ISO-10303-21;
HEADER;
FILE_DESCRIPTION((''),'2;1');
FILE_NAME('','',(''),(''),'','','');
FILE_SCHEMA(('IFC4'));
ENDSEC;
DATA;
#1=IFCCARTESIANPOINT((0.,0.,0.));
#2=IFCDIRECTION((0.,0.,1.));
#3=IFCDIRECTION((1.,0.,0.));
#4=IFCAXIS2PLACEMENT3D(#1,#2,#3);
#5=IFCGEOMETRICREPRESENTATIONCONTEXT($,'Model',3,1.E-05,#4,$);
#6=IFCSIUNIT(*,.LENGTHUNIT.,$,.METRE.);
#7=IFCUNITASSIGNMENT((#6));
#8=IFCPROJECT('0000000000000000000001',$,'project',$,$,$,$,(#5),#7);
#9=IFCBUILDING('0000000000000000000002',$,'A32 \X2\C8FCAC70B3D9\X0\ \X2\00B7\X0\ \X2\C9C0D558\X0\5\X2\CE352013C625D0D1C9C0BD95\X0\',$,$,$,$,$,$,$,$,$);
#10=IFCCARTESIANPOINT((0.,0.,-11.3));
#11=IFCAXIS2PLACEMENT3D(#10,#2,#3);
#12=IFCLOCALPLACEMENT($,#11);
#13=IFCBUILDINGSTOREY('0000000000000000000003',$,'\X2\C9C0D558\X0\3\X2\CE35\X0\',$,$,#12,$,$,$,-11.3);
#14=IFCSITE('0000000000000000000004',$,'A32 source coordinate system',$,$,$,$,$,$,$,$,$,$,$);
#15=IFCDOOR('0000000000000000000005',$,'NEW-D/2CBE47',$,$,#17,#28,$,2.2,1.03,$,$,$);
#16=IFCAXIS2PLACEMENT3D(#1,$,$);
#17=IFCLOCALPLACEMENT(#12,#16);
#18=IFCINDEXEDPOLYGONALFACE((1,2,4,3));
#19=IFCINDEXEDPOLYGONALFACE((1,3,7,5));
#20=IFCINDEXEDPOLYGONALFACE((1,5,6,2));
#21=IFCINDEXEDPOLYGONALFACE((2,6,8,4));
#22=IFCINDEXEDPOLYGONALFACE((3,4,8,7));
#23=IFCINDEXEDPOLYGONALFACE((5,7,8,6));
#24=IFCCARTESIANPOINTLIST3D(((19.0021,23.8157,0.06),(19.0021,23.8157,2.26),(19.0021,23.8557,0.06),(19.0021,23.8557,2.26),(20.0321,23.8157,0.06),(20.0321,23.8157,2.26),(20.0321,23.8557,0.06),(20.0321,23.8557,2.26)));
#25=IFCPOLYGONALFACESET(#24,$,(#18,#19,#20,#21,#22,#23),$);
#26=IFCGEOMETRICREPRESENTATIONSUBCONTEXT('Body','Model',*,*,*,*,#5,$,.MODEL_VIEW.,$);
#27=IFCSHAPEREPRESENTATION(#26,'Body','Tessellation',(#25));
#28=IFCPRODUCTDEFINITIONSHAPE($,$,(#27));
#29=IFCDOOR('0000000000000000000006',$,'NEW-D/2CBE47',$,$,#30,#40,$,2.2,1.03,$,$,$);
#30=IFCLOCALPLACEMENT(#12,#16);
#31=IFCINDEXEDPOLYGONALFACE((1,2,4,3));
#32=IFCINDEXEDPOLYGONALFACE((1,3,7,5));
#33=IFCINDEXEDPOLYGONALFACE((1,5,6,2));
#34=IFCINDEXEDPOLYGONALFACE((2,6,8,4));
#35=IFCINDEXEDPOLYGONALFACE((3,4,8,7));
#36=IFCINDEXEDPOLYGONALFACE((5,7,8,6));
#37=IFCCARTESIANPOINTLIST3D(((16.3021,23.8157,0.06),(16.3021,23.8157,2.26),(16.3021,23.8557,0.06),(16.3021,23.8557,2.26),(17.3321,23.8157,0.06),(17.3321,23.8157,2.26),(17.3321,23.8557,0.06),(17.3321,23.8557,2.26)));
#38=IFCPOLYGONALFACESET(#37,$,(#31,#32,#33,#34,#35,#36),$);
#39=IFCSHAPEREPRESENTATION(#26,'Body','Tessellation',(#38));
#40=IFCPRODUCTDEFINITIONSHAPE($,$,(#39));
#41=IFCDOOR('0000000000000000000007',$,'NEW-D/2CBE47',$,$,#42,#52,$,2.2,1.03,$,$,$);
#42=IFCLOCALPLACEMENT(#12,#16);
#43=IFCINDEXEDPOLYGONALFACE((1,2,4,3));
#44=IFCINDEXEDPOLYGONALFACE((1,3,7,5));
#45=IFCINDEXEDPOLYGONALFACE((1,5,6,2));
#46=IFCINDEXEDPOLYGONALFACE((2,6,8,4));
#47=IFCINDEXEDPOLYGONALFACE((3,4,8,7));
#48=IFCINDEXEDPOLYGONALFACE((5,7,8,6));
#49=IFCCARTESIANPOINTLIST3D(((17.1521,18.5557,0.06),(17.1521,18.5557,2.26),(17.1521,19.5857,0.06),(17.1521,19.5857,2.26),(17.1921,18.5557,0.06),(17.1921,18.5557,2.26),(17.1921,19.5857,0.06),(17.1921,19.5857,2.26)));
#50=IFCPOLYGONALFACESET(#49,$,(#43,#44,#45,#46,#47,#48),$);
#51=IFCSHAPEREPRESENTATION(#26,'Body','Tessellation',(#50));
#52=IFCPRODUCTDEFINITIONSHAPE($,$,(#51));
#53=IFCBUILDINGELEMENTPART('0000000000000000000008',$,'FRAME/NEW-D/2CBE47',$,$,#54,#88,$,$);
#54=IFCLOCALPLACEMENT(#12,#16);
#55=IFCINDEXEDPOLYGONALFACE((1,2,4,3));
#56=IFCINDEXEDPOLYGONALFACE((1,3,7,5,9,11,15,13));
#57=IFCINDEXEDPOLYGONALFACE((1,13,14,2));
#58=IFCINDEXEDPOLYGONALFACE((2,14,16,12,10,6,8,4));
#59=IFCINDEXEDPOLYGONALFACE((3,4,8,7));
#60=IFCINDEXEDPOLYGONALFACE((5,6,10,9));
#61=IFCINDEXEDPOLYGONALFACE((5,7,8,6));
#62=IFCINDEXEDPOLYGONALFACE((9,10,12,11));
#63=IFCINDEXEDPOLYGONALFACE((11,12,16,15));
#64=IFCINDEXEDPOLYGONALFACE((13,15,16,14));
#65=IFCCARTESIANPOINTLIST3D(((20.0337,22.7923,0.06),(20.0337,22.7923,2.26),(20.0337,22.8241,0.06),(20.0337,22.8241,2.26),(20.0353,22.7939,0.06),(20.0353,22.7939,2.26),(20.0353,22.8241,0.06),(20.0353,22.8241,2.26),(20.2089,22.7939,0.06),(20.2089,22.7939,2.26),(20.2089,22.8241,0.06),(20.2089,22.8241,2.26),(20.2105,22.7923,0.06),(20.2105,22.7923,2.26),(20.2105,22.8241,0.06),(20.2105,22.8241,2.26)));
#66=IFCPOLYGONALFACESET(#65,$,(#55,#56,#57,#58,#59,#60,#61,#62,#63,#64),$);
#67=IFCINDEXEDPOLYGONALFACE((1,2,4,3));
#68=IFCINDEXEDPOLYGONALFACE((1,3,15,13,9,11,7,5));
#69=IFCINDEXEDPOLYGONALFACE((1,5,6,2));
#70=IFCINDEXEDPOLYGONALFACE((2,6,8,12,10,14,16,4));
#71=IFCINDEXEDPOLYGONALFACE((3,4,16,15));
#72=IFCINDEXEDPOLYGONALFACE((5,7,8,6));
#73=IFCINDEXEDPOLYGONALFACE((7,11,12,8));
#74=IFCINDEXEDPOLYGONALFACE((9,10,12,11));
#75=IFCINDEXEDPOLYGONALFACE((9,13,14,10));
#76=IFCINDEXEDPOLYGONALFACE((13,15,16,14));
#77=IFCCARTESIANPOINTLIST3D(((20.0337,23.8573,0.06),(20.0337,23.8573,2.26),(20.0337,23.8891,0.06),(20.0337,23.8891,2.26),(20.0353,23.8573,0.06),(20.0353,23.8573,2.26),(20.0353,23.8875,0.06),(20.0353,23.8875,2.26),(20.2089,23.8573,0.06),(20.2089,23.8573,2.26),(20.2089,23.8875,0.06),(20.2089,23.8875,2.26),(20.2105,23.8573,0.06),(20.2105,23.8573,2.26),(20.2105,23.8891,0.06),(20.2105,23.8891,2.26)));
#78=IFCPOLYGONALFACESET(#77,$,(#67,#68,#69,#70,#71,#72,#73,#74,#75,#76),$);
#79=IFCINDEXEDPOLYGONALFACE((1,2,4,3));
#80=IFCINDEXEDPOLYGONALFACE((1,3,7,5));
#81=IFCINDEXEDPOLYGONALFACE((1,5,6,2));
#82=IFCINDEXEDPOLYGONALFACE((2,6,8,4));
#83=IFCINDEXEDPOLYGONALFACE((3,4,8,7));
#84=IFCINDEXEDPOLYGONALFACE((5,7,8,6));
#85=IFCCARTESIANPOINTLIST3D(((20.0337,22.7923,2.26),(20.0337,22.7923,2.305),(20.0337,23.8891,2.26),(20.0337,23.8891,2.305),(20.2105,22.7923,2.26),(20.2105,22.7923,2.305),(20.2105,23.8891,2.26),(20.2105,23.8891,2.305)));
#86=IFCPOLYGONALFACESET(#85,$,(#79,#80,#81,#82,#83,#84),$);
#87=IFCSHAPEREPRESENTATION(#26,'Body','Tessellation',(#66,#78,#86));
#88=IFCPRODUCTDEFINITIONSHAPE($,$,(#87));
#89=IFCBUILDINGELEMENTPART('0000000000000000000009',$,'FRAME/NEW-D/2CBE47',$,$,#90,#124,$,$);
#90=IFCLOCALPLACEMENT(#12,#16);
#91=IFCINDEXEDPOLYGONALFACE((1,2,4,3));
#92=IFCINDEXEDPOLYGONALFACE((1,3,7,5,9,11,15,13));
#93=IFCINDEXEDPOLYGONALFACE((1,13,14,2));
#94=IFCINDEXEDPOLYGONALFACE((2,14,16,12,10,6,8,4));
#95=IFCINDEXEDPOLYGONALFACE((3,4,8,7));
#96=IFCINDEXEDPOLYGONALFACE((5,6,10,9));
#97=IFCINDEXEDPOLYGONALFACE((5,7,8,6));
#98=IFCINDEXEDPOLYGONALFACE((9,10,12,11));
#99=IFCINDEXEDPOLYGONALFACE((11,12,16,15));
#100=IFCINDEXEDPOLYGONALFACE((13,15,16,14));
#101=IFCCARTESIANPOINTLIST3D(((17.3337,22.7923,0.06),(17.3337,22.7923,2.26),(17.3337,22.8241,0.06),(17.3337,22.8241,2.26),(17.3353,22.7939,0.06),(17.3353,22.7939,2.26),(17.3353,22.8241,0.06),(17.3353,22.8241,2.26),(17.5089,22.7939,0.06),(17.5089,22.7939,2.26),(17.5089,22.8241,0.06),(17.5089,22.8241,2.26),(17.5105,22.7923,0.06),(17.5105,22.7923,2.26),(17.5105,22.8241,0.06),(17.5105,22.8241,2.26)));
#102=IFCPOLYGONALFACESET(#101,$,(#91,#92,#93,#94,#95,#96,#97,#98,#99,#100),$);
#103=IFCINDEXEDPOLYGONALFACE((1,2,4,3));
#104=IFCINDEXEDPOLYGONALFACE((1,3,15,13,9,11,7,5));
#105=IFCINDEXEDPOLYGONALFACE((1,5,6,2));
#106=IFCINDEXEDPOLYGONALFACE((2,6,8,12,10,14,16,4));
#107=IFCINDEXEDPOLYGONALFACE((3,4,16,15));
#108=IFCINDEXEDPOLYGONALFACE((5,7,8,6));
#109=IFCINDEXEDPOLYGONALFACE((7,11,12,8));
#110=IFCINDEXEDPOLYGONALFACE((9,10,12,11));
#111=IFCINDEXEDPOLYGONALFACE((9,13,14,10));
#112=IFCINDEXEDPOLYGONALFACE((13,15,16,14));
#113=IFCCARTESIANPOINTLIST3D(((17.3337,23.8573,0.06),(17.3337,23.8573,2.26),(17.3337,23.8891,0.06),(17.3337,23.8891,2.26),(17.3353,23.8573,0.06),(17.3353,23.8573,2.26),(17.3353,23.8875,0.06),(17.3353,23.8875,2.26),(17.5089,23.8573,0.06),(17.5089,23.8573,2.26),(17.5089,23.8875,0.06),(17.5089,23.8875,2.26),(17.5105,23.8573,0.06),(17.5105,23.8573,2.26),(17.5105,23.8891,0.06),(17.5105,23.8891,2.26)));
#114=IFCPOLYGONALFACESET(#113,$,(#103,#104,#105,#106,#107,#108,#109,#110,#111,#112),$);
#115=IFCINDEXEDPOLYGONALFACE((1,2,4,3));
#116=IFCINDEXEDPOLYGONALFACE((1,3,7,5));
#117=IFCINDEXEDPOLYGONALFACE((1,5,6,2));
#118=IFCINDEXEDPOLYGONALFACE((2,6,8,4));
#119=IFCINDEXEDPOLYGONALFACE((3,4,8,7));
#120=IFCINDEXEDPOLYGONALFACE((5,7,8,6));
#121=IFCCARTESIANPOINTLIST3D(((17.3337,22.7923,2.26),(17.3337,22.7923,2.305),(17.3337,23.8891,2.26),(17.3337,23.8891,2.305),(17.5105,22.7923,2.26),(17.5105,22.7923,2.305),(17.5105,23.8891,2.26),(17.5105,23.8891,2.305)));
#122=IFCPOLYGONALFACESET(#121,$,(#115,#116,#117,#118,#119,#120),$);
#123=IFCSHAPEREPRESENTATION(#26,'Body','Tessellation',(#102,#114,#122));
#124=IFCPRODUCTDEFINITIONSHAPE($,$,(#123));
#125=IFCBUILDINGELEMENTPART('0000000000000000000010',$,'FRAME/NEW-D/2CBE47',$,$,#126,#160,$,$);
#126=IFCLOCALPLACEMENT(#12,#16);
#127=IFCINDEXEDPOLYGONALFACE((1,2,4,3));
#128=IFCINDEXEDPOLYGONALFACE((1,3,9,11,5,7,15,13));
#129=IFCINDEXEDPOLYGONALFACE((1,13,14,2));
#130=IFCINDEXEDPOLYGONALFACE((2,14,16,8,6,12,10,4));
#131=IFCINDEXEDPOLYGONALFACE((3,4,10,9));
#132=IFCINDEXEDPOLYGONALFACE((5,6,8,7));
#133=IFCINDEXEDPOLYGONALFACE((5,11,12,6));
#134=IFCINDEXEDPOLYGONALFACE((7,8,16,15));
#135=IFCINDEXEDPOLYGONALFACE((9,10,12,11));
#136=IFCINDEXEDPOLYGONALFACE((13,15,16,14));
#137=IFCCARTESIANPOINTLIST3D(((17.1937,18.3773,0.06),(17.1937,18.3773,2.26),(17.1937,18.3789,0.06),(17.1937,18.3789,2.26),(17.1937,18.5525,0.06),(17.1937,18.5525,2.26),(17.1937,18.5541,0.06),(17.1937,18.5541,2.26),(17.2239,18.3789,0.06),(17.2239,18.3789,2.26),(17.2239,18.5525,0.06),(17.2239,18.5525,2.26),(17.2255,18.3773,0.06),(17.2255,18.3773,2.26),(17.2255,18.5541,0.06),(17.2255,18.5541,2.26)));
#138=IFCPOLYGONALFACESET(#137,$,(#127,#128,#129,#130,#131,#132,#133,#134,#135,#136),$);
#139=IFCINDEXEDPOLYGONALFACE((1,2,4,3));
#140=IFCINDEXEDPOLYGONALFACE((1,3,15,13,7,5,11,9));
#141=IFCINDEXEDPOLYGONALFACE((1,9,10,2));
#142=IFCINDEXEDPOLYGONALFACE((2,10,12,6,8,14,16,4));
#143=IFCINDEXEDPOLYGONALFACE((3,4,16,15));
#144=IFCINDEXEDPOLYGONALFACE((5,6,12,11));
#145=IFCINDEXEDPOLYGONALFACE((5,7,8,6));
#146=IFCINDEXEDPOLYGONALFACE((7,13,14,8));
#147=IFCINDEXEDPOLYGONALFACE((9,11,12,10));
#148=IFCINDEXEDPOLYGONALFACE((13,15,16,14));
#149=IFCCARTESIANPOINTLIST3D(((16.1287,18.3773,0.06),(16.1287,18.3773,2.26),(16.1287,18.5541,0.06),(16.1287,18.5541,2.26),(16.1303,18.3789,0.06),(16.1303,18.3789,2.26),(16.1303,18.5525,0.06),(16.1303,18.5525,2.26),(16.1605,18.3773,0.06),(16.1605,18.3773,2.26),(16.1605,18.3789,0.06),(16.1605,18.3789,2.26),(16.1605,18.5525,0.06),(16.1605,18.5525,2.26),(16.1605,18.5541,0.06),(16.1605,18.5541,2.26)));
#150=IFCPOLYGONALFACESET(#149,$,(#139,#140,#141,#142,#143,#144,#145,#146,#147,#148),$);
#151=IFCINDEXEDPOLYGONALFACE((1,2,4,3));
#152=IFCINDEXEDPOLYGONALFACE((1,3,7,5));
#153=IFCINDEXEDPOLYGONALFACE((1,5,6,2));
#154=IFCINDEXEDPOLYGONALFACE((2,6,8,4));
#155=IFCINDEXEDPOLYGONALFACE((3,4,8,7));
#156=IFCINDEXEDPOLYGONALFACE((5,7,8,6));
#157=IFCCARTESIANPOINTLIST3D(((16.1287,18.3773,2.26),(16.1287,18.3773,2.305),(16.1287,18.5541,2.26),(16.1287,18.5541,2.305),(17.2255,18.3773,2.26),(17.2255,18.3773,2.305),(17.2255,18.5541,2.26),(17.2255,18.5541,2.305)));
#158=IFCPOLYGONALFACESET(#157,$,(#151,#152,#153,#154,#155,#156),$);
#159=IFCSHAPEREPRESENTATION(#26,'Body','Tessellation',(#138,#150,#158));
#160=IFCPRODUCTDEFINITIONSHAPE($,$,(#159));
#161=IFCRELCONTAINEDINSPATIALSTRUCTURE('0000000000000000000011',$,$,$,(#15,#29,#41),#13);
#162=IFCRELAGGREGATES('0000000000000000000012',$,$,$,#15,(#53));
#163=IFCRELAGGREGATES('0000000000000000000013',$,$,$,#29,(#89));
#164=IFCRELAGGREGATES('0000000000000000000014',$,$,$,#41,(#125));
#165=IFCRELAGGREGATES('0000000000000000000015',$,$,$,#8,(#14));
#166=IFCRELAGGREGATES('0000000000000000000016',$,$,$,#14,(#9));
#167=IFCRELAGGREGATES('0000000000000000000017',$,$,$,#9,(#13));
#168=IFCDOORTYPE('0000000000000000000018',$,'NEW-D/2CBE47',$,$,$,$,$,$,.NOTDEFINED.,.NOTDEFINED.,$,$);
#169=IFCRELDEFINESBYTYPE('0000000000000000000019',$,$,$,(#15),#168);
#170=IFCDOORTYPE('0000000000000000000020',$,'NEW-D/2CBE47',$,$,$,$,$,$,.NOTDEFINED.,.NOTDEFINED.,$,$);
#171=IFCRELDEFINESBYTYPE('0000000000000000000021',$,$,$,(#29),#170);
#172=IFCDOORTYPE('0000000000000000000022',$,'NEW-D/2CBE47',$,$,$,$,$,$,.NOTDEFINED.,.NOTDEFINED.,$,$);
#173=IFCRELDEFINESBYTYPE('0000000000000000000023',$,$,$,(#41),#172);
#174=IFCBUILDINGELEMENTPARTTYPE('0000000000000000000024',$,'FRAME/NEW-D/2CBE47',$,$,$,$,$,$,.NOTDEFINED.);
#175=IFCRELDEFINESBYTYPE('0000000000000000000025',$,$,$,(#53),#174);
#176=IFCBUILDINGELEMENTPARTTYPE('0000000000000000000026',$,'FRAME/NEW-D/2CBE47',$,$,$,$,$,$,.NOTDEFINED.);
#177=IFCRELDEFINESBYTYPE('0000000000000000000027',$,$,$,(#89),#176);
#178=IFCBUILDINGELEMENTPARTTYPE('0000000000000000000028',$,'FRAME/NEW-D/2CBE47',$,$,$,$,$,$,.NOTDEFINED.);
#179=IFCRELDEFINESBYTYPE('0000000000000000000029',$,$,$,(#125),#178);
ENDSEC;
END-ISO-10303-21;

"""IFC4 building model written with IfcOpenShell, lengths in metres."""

from ifc_helpers import new_model, si_unit, frame, origin, origin_with_axes, place, context, subcontext, project, spatial, polyline, outline, extrude, source, transform, mapped, type_object, type_shapes, element, aggregate, save


model = new_model("IFC4")

# Units and contexts
model_context = context("Model", 3, precision=1e-05, world=origin_with_axes())
body_context = subcontext(model_context, "Body", "Model", "MODEL_VIEW")
ifc_project = project(units=[si_unit("LENGTHUNIT", "METRE")], contexts=[model_context])

# Site, building, storey
site = spatial("IfcSite", under=ifc_project, Name="A32 source coordinate system")
building = spatial("IfcBuilding", under=site, Name="A32 주거동 · 지하5층–옥탑지붕")
storey_placement = place(None, frame((0.0, 0.0, -11.3), z_axis=(0.0, 0.0, 1.0), x_axis=(1.0, 0.0, 0.0)))
storey = spatial("IfcBuildingStorey", under=building, at=storey_placement, Name="지하3층", Elevation=-11.3)

# Doors
door_type_1 = type_object("IfcDoorType", Name="NEW-D/2CBE47", OperationType="NOTDEFINED", PredefinedType="NOTDEFINED")
shared_shape_1 = source(origin(), body_context, "Body", "SweptSolid", [
    extrude(outline(polyline([(20.0321, 23.8557), (20.0321, 23.8157), (19.0021, 23.8157), (19.0021, 23.8557), (20.0321, 23.8557)])), frame((0.0, 0.0, 0.06)), (0.0, 0.0, 1.0), 2.2),
])
type_shapes(door_type_1, [shared_shape_1])
door_1_placement = place(storey_placement, origin_with_axes())
door_1 = element("IfcDoor", 1, at=door_1_placement, inside=storey, type_object=door_type_1, Name="NEW-D/2CBE47", OverallHeight=2.2, OverallWidth=1.03, context=body_context, shape_type="MappedRepresentation", body=[
    mapped(shared_shape_1, transform((0.0, 0.0, 0.0), scale=1.0)),
])
door_type_2 = type_object("IfcDoorType", Name="NEW-D/2CBE47", OperationType="NOTDEFINED", PredefinedType="NOTDEFINED")
shared_shape_2 = source(origin(), body_context, "Body", "SweptSolid", [
    extrude(outline(polyline([(17.3321, 23.8557), (17.3321, 23.8157), (16.3021, 23.8157), (16.3021, 23.8557), (17.3321, 23.8557)])), frame((0.0, 0.0, 0.06)), (0.0, 0.0, 1.0), 2.2),
])
type_shapes(door_type_2, [shared_shape_2])
door_2_placement = place(storey_placement, origin_with_axes())
door_2 = element("IfcDoor", 2, at=door_2_placement, inside=storey, type_object=door_type_2, Name="NEW-D/2CBE47", OverallHeight=2.2, OverallWidth=1.03, context=body_context, shape_type="MappedRepresentation", body=[
    mapped(shared_shape_2, transform((0.0, 0.0, 0.0), scale=1.0)),
])
door_type_3 = type_object("IfcDoorType", Name="NEW-D/2CBE47", OperationType="NOTDEFINED", PredefinedType="NOTDEFINED")
shared_shape_3 = source(origin(), body_context, "Body", "SweptSolid", [
    extrude(outline(polyline([(17.1921, 18.5557), (17.1521, 18.5557), (17.1521, 19.5857), (17.1921, 19.5857), (17.1921, 18.5557)])), frame((0.0, 0.0, 0.06)), (0.0, 0.0, 1.0), 2.2),
])
type_shapes(door_type_3, [shared_shape_3])
door_3_placement = place(storey_placement, origin_with_axes())
door_3 = element("IfcDoor", 3, at=door_3_placement, inside=storey, type_object=door_type_3, Name="NEW-D/2CBE47", OverallHeight=2.2, OverallWidth=1.03, context=body_context, shape_type="MappedRepresentation", body=[
    mapped(shared_shape_3, transform((0.0, 0.0, 0.0), scale=1.0)),
])

# Building element parts
building_element_part_type_1 = type_object("IfcBuildingElementPartType", Name="FRAME/NEW-D/2CBE47", PredefinedType="NOTDEFINED")
shared_shape_4 = source(origin(), body_context, "Body", "SweptSolid", [
    extrude(outline(polyline([(20.0353, 22.7939), (20.2089, 22.7939), (20.2089, 22.8241), (20.2105, 22.8241), (20.2105, 22.7923), (20.0337, 22.7923), (20.0337, 22.8241), (20.0353, 22.8241), (20.0353, 22.7939)])), frame((0.0, 0.0, 0.06)), (0.0, 0.0, 1.0), 2.2),
    extrude(outline(polyline([(20.2105, 23.8891), (20.2105, 23.8573), (20.2089, 23.8573), (20.2089, 23.8875), (20.0353, 23.8875), (20.0353, 23.8573), (20.0337, 23.8573), (20.0337, 23.8891), (20.2105, 23.8891)])), frame((0.0, 0.0, 0.06)), (0.0, 0.0, 1.0), 2.2),
    extrude(outline(polyline([(20.2105, 22.7923), (20.2105, 23.8891), (20.0337, 23.8891), (20.0337, 22.7923), (20.2105, 22.7923)])), frame((0.0, 0.0, 2.26)), (0.0, 0.0, 1.0), 0.045),
])
type_shapes(building_element_part_type_1, [shared_shape_4])
building_element_part_1_placement = place(door_1_placement, origin_with_axes())
building_element_part_1 = element("IfcBuildingElementPart", 4, at=building_element_part_1_placement, type_object=building_element_part_type_1, Name="FRAME/NEW-D/2CBE47", context=body_context, shape_type="MappedRepresentation", body=[
    mapped(shared_shape_4, transform((0.0, 0.0, 0.0), scale=1.0)),
])
aggregate(door_1, [building_element_part_1])
building_element_part_type_2 = type_object("IfcBuildingElementPartType", Name="FRAME/NEW-D/2CBE47", PredefinedType="NOTDEFINED")
shared_shape_5 = source(origin(), body_context, "Body", "SweptSolid", [
    extrude(outline(polyline([(17.3353, 22.7939), (17.5089, 22.7939), (17.5089, 22.8241), (17.5105, 22.8241), (17.5105, 22.7923), (17.3337, 22.7923), (17.3337, 22.8241), (17.3353, 22.8241), (17.3353, 22.7939)])), frame((0.0, 0.0, 0.06)), (0.0, 0.0, 1.0), 2.2),
    extrude(outline(polyline([(17.5105, 23.8891), (17.5105, 23.8573), (17.5089, 23.8573), (17.5089, 23.8875), (17.3353, 23.8875), (17.3353, 23.8573), (17.3337, 23.8573), (17.3337, 23.8891), (17.5105, 23.8891)])), frame((0.0, 0.0, 0.06)), (0.0, 0.0, 1.0), 2.2),
    extrude(outline(polyline([(17.5105, 22.7923), (17.5105, 23.8891), (17.3337, 23.8891), (17.3337, 22.7923), (17.5105, 22.7923)])), frame((0.0, 0.0, 2.26)), (0.0, 0.0, 1.0), 0.045),
])
type_shapes(building_element_part_type_2, [shared_shape_5])
building_element_part_2_placement = place(door_2_placement, origin_with_axes())
building_element_part_2 = element("IfcBuildingElementPart", 5, at=building_element_part_2_placement, type_object=building_element_part_type_2, Name="FRAME/NEW-D/2CBE47", context=body_context, shape_type="MappedRepresentation", body=[
    mapped(shared_shape_5, transform((0.0, 0.0, 0.0), scale=1.0)),
])
aggregate(door_2, [building_element_part_2])
building_element_part_type_3 = type_object("IfcBuildingElementPartType", Name="FRAME/NEW-D/2CBE47", PredefinedType="NOTDEFINED")
shared_shape_6 = source(origin(), body_context, "Body", "SweptSolid", [
    extrude(outline(polyline([(17.2255, 18.3773), (17.1937, 18.3773), (17.1937, 18.3789), (17.2239, 18.3789), (17.2239, 18.5525), (17.1937, 18.5525), (17.1937, 18.5541), (17.2255, 18.5541), (17.2255, 18.3773)])), frame((0.0, 0.0, 0.06)), (0.0, 0.0, 1.0), 2.2),
    extrude(outline(polyline([(16.1303, 18.5525), (16.1303, 18.3789), (16.1605, 18.3789), (16.1605, 18.3773), (16.1287, 18.3773), (16.1287, 18.5541), (16.1605, 18.5541), (16.1605, 18.5525), (16.1303, 18.5525)])), frame((0.0, 0.0, 0.06)), (0.0, 0.0, 1.0), 2.2),
    extrude(outline(polyline([(17.2255, 18.3773), (17.2255, 18.5541), (16.1287, 18.5541), (16.1287, 18.3773), (17.2255, 18.3773)])), frame((0.0, 0.0, 2.26)), (0.0, 0.0, 1.0), 0.045),
])
type_shapes(building_element_part_type_3, [shared_shape_6])
building_element_part_3_placement = place(door_3_placement, origin_with_axes())
building_element_part_3 = element("IfcBuildingElementPart", 6, at=building_element_part_3_placement, type_object=building_element_part_type_3, Name="FRAME/NEW-D/2CBE47", context=body_context, shape_type="MappedRepresentation", body=[
    mapped(shared_shape_6, transform((0.0, 0.0, 0.0), scale=1.0)),
])
aggregate(door_3, [building_element_part_3])

save(model, "model.ifc")
